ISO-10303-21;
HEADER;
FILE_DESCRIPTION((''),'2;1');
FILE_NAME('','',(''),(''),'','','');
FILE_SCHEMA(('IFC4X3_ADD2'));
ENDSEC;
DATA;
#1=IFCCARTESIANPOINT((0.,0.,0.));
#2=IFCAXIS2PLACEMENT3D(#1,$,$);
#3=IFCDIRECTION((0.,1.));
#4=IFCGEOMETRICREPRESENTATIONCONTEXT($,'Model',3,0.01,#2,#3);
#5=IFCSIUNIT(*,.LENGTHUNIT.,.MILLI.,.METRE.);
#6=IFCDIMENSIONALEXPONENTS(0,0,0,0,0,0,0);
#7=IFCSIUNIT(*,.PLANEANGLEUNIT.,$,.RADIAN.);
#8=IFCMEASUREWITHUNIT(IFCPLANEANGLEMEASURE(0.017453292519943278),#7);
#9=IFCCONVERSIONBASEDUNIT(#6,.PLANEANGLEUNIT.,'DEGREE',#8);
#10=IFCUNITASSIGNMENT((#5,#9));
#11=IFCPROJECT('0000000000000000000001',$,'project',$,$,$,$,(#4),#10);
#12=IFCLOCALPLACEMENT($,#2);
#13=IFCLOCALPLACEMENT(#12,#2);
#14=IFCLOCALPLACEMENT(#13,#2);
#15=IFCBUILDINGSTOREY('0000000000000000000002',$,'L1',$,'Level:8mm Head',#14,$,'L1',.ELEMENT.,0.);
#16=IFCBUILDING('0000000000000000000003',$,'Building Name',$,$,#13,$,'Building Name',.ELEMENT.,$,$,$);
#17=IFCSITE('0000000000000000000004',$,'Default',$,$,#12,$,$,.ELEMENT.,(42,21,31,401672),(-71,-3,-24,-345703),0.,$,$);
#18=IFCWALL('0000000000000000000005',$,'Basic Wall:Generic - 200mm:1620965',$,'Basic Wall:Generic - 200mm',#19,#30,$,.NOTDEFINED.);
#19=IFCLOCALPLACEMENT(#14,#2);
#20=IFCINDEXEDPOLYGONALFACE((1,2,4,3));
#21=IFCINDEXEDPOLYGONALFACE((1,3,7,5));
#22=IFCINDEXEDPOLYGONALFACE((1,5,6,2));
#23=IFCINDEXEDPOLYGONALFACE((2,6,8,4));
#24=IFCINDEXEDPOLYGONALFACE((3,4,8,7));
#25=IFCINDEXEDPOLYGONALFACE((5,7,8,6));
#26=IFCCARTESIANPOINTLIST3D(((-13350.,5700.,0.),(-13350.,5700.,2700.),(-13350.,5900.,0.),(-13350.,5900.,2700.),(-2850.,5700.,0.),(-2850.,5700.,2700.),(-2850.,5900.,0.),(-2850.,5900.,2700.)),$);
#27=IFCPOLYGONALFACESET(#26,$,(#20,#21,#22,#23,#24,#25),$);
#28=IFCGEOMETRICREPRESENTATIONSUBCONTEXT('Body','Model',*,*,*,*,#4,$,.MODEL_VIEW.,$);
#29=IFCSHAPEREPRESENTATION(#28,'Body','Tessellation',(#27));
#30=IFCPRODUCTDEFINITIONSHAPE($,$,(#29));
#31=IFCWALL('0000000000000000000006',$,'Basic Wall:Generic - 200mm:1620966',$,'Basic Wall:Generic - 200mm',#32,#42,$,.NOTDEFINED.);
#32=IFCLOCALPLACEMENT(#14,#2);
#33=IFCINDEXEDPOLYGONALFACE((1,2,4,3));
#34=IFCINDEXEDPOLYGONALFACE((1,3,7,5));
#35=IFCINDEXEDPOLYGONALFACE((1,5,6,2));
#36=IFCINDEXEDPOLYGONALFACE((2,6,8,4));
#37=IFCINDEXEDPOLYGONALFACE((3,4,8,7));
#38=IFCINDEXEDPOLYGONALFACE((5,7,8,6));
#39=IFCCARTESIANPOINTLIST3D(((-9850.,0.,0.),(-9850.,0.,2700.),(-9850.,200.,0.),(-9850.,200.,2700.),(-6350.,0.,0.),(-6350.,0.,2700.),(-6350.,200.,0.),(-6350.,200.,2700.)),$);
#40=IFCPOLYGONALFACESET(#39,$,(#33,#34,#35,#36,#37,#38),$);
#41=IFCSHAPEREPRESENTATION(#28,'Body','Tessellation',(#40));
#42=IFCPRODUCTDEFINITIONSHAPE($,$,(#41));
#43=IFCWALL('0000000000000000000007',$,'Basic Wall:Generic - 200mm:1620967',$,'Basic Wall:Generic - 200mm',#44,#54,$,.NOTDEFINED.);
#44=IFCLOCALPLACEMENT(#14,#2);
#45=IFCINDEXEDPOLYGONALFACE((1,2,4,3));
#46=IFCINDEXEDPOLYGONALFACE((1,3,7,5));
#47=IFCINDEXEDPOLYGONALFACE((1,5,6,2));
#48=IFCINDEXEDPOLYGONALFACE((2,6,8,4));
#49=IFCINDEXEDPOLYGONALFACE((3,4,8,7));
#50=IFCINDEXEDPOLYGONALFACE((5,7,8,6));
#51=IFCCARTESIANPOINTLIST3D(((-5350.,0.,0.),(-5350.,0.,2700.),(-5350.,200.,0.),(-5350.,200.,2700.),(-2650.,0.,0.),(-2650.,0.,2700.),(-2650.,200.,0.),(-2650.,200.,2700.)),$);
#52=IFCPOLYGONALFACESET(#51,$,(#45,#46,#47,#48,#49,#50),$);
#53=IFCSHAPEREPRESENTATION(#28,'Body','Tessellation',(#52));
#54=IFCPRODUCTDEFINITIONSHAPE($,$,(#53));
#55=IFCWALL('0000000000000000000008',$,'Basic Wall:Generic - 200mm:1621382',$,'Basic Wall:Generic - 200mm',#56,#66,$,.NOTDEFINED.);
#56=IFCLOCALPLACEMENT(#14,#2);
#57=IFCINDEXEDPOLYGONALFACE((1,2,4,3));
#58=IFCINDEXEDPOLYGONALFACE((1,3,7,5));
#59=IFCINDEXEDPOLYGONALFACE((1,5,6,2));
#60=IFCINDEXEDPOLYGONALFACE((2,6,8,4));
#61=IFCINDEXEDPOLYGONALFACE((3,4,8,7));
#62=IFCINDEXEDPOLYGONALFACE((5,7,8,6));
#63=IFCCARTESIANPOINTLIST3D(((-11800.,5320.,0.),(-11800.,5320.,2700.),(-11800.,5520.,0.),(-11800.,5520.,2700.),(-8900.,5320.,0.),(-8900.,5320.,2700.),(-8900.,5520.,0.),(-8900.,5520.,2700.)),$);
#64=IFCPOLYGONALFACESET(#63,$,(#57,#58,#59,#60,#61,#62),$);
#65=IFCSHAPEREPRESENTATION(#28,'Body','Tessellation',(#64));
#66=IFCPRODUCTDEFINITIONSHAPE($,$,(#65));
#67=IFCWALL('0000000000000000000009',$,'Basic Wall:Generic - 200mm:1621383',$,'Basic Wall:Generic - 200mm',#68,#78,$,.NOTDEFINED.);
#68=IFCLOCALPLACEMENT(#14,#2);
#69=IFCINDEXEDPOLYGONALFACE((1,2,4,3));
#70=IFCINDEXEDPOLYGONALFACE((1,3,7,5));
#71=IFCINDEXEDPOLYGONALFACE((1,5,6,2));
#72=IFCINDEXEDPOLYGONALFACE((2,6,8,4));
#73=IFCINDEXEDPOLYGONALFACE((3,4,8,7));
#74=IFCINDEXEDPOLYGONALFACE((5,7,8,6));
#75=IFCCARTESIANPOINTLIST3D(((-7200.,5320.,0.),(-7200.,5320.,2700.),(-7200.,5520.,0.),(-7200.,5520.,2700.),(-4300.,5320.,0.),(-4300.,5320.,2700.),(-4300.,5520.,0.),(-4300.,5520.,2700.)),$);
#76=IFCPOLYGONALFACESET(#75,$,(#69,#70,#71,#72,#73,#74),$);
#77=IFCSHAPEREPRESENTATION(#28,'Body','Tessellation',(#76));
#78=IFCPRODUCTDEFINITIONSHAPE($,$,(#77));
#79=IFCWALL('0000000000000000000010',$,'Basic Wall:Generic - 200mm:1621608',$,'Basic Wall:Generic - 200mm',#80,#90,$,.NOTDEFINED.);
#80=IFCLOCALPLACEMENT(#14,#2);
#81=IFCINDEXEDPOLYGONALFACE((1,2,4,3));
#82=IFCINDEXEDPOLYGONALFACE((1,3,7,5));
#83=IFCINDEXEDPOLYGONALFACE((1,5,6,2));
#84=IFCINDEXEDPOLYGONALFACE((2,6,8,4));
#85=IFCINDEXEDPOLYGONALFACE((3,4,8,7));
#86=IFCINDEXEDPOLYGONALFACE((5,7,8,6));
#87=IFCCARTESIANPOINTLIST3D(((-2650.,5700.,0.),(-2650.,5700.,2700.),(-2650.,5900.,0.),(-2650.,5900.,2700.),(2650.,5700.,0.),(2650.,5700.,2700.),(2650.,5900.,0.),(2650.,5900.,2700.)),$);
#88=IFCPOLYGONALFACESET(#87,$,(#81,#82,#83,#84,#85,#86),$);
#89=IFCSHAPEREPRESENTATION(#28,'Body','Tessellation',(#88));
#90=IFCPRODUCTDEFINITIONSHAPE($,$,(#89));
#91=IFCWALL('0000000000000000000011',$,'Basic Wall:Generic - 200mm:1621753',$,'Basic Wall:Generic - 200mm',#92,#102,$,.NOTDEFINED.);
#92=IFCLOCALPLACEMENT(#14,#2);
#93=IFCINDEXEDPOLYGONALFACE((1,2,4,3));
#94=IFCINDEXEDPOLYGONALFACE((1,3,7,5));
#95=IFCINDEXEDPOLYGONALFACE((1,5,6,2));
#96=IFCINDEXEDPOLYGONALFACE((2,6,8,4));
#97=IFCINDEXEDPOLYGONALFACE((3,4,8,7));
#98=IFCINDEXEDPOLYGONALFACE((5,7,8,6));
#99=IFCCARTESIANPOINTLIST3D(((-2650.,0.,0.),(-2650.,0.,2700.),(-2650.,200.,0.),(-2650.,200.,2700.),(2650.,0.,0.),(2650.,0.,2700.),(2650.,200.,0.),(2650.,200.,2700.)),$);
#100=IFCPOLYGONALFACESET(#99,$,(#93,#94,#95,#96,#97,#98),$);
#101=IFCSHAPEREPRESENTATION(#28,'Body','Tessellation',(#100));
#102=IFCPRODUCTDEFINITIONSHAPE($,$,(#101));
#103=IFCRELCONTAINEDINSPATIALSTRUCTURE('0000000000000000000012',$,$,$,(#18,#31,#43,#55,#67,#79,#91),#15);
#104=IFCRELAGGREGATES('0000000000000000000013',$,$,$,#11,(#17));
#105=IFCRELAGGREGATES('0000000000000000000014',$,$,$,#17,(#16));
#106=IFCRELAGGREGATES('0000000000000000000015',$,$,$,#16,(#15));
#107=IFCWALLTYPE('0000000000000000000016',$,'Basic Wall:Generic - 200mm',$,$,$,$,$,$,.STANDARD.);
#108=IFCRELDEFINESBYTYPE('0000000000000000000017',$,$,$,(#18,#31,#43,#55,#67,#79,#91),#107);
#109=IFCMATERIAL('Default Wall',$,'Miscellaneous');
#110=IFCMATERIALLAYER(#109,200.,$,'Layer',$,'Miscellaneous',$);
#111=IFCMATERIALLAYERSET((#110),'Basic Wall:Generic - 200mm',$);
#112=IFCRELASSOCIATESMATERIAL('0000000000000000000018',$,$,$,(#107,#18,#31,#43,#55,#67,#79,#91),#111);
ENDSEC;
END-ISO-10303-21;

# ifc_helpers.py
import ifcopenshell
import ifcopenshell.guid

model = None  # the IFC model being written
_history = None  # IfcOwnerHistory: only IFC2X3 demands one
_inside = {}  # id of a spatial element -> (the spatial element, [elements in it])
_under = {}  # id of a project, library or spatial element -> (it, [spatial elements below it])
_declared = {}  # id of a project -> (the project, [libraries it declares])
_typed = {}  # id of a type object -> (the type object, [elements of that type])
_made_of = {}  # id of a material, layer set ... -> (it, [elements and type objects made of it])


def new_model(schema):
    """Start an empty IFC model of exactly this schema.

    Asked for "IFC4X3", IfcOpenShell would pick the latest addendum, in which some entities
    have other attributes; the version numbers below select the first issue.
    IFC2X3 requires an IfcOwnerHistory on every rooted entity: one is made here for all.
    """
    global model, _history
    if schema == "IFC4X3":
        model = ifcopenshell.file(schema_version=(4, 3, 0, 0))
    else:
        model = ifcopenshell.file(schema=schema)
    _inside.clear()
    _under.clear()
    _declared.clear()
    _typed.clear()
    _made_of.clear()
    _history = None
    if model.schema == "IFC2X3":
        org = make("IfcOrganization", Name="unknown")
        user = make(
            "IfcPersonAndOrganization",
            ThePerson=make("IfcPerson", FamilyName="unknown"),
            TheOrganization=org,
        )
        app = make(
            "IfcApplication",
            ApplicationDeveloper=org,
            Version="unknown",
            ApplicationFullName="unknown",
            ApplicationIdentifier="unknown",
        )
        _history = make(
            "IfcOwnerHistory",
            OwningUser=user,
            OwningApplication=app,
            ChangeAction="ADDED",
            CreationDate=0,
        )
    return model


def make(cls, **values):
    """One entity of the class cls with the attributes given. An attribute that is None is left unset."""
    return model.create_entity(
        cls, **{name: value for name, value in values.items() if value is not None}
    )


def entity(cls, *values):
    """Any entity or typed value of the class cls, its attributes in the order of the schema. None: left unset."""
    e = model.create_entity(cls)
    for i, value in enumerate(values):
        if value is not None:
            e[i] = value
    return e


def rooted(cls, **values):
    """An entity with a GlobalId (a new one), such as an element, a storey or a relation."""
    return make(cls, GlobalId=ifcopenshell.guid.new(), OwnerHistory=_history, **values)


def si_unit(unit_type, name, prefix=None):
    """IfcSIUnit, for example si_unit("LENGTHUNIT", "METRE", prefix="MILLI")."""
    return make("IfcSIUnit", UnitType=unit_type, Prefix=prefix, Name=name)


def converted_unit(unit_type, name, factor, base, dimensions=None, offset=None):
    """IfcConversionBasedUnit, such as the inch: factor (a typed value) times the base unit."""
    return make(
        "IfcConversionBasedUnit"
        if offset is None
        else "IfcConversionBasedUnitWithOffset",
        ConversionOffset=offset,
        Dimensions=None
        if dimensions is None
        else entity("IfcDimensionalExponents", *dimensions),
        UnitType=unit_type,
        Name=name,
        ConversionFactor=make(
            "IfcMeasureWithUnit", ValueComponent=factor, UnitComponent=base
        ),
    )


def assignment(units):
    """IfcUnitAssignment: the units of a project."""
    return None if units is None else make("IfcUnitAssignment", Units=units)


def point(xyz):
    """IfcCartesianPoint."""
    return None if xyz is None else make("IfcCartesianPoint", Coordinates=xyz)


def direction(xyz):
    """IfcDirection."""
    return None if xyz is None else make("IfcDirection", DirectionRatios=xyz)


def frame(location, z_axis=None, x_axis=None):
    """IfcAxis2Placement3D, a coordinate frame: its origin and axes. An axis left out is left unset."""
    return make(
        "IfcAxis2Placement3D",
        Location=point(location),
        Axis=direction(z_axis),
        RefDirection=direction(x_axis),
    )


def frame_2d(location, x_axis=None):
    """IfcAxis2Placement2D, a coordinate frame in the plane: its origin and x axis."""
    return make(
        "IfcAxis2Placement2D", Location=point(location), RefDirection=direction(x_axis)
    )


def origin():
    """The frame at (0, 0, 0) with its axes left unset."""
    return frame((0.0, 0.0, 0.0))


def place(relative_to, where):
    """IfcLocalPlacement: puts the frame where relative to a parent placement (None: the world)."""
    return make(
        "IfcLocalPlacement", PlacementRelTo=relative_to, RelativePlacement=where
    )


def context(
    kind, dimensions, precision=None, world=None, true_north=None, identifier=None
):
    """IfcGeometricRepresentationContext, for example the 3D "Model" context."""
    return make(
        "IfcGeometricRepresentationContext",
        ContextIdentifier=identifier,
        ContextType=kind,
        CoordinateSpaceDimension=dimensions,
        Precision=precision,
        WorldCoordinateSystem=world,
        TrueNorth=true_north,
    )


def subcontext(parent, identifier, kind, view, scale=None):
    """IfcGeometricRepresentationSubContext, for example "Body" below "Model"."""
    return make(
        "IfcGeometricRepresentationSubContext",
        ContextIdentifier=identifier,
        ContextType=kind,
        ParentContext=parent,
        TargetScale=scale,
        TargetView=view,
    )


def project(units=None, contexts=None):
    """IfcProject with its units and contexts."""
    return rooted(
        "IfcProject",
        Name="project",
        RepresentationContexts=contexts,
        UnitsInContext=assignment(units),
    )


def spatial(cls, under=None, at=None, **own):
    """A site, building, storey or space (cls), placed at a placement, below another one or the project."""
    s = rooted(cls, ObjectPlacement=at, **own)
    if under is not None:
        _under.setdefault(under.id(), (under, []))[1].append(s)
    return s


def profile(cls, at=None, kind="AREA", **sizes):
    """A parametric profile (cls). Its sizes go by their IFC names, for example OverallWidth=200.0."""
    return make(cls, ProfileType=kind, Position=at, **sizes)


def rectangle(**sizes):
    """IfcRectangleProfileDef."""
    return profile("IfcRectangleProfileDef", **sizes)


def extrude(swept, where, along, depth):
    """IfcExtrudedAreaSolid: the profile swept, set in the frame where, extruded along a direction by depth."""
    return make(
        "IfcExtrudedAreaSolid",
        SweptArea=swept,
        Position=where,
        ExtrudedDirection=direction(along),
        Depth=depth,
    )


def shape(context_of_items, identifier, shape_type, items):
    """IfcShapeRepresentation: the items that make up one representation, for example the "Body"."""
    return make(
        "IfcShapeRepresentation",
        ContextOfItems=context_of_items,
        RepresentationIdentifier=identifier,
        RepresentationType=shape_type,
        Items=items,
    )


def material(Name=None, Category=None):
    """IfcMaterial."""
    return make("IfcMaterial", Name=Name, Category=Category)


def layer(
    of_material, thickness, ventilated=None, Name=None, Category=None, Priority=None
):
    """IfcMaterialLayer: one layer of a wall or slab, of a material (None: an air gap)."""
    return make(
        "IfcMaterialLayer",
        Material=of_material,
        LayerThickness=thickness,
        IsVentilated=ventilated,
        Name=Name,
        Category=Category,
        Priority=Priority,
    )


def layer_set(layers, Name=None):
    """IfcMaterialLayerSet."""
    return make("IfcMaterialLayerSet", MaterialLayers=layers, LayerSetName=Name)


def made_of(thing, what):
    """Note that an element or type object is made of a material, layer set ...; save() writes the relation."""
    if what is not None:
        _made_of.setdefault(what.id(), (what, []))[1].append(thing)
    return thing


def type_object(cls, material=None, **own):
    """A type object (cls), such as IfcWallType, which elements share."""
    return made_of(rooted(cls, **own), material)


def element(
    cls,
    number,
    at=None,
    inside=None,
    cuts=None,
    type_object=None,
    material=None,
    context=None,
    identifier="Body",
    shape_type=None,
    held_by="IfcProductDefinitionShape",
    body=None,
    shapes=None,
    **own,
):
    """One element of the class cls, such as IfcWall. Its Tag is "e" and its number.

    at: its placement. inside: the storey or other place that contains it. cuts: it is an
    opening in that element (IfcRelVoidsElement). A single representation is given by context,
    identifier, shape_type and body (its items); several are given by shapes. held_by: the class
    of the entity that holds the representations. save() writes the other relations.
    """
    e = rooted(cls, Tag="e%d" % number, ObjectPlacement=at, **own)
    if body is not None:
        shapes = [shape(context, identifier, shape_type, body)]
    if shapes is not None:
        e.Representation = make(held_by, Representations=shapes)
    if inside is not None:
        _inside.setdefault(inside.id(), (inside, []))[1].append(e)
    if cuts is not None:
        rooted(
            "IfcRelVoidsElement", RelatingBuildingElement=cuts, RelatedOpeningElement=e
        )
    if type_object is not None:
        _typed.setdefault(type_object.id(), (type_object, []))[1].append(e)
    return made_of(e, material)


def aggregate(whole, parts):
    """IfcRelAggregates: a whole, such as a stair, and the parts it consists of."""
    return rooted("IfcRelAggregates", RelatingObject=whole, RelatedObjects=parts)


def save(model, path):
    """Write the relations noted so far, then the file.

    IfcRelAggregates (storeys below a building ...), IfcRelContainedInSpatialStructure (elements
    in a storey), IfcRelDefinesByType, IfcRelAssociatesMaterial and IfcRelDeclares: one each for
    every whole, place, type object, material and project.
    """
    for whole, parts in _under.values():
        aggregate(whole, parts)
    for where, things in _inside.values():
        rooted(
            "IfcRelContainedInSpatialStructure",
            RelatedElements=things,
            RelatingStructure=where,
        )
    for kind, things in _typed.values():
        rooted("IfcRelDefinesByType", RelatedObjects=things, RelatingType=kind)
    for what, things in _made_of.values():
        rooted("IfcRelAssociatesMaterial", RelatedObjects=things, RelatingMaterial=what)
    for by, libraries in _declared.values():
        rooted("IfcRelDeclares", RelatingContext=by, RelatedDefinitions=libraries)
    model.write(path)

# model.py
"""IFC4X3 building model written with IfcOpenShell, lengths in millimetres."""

from ifc_helpers import new_model, entity, si_unit, converted_unit, direction, frame, frame_2d, origin, place, context, subcontext, project, spatial, rectangle, extrude, material, layer, layer_set, type_object, element, save


model = new_model("IFC4X3")

# Units and contexts
model_context = context("Model", 3, precision=0.01, world=origin(), true_north=direction((0.0, 1.0)))
body_context = subcontext(model_context, "Body", "Model", "MODEL_VIEW")
ifc_project = project(units=[si_unit("LENGTHUNIT", "METRE", prefix="MILLI"), converted_unit("PLANEANGLEUNIT", "DEGREE", entity("IfcPlaneAngleMeasure", 0.017453292519943278), si_unit("PLANEANGLEUNIT", "RADIAN"), dimensions=[0, 0, 0, 0, 0, 0, 0])], contexts=[model_context])

# Site, building, storey
site_placement = place(None, origin())
site = spatial("IfcSite", under=ifc_project, at=site_placement, Name="Default", CompositionType="ELEMENT", RefLatitude=(42, 21, 31, 401672), RefLongitude=(-71, -3, -24, -345703), RefElevation=0.0)
building_placement = place(site_placement, origin())
building = spatial("IfcBuilding", under=site, at=building_placement, Name="Building Name", LongName="Building Name", CompositionType="ELEMENT")
storey_placement = place(building_placement, origin())
storey = spatial("IfcBuildingStorey", under=building, at=storey_placement, Name="L1", ObjectType="Level:8mm Head", LongName="L1", CompositionType="ELEMENT", Elevation=0.0)

# Shared definitions
ifc_material_1 = material(Name="Default Wall", Category="Miscellaneous")
ifc_layer_1 = layer(ifc_material_1, 200.0, Name="Layer", Category="Miscellaneous")
ifc_layer_set_1 = layer_set([ifc_layer_1], Name="Basic Wall:Generic - 200mm")
wall_type = type_object("IfcWallType", Name="Basic Wall:Generic - 200mm", PredefinedType="STANDARD", material=ifc_layer_set_1)

# Walls
wall_1_placement = place(storey_placement, frame((-2850.0, 5800.0, 0.0), z_axis=(0.0, 0.0, 1.0), x_axis=(-1.0, 0.0, 0.0)))
element("IfcWall", 1, at=wall_1_placement, inside=storey, type_object=wall_type, material=ifc_layer_set_1, Name="Basic Wall:Generic - 200mm:1620965", ObjectType="Basic Wall:Generic - 200mm", PredefinedType="NOTDEFINED", context=body_context, shape_type="SweptSolid", body=[
    extrude(rectangle(XDim=10500.0, YDim=200.0, at=frame_2d((5250.0, 0.0), x_axis=(-1.0, 0.0))), origin(), (0.0, 0.0, 1.0), 2700.0),
])
wall_2_placement = place(storey_placement, frame((-9850.0, 100.0, 0.0)))
element("IfcWall", 2, at=wall_2_placement, inside=storey, type_object=wall_type, material=ifc_layer_set_1, Name="Basic Wall:Generic - 200mm:1620966", ObjectType="Basic Wall:Generic - 200mm", PredefinedType="NOTDEFINED", context=body_context, shape_type="SweptSolid", body=[
    extrude(rectangle(XDim=3500.0, YDim=200.0, at=frame_2d((1750.0, 0.0), x_axis=(-1.0, 0.0))), origin(), (0.0, 0.0, 1.0), 2700.0),
])
wall_3_placement = place(storey_placement, frame((-5350.0, 100.0, 0.0)))
element("IfcWall", 3, at=wall_3_placement, inside=storey, type_object=wall_type, material=ifc_layer_set_1, Name="Basic Wall:Generic - 200mm:1620967", ObjectType="Basic Wall:Generic - 200mm", PredefinedType="NOTDEFINED", context=body_context, shape_type="SweptSolid", body=[
    extrude(rectangle(XDim=2700.0, YDim=200.0, at=frame_2d((1350.0, 0.0), x_axis=(-1.0, 0.0))), origin(), (0.0, 0.0, 1.0), 2700.0),
])
for number, where, z_axis, x_axis, name in (
    (4, (-8900.0, 5420.0, 0.0), (0.0, 0.0, 1.0), (-1.0, 0.0, 0.0), "Basic Wall:Generic - 200mm:1621382"),
    (5, (-4300.0, 5420.0, 0.0), (0.0, 0.0, 1.0), (-1.0, 0.0, 0.0), "Basic Wall:Generic - 200mm:1621383"),
):
    element("IfcWall", number, at=place(storey_placement, frame(where, z_axis=z_axis, x_axis=x_axis)), inside=storey, type_object=wall_type, material=ifc_layer_set_1, Name=name, ObjectType="Basic Wall:Generic - 200mm", PredefinedType="NOTDEFINED", context=body_context, shape_type="SweptSolid", body=[
        extrude(rectangle(XDim=2900.0, YDim=200.0, at=frame_2d((1450.0, 0.0), x_axis=(-1.0, 0.0))), origin(), (0.0, 0.0, 1.0), 2700.0),
    ])
wall_4_placement = place(storey_placement, frame((-2650.0, 5800.0, 0.0)))
element("IfcWall", 6, at=wall_4_placement, inside=storey, type_object=wall_type, material=ifc_layer_set_1, Name="Basic Wall:Generic - 200mm:1621608", ObjectType="Basic Wall:Generic - 200mm", PredefinedType="NOTDEFINED", context=body_context, shape_type="SweptSolid", body=[
    extrude(rectangle(XDim=5300.0, YDim=200.0, at=frame_2d((2650.0, 0.0), x_axis=(-1.0, 0.0))), origin(), (0.0, 0.0, 1.0), 2700.0),
])
wall_5_placement = place(storey_placement, frame((2650.0, 100.0, 0.0), z_axis=(0.0, 0.0, 1.0), x_axis=(-1.0, 0.0, 0.0)))
element("IfcWall", 7, at=wall_5_placement, inside=storey, type_object=wall_type, material=ifc_layer_set_1, Name="Basic Wall:Generic - 200mm:1621753", ObjectType="Basic Wall:Generic - 200mm", PredefinedType="NOTDEFINED", context=body_context, shape_type="SweptSolid", body=[
    extrude(rectangle(XDim=5300.0, YDim=200.0, at=frame_2d((2650.0, 0.0), x_axis=(-1.0, 0.0))), origin(), (0.0, 0.0, 1.0), 2700.0),
])

save(model, "model.ifc")
